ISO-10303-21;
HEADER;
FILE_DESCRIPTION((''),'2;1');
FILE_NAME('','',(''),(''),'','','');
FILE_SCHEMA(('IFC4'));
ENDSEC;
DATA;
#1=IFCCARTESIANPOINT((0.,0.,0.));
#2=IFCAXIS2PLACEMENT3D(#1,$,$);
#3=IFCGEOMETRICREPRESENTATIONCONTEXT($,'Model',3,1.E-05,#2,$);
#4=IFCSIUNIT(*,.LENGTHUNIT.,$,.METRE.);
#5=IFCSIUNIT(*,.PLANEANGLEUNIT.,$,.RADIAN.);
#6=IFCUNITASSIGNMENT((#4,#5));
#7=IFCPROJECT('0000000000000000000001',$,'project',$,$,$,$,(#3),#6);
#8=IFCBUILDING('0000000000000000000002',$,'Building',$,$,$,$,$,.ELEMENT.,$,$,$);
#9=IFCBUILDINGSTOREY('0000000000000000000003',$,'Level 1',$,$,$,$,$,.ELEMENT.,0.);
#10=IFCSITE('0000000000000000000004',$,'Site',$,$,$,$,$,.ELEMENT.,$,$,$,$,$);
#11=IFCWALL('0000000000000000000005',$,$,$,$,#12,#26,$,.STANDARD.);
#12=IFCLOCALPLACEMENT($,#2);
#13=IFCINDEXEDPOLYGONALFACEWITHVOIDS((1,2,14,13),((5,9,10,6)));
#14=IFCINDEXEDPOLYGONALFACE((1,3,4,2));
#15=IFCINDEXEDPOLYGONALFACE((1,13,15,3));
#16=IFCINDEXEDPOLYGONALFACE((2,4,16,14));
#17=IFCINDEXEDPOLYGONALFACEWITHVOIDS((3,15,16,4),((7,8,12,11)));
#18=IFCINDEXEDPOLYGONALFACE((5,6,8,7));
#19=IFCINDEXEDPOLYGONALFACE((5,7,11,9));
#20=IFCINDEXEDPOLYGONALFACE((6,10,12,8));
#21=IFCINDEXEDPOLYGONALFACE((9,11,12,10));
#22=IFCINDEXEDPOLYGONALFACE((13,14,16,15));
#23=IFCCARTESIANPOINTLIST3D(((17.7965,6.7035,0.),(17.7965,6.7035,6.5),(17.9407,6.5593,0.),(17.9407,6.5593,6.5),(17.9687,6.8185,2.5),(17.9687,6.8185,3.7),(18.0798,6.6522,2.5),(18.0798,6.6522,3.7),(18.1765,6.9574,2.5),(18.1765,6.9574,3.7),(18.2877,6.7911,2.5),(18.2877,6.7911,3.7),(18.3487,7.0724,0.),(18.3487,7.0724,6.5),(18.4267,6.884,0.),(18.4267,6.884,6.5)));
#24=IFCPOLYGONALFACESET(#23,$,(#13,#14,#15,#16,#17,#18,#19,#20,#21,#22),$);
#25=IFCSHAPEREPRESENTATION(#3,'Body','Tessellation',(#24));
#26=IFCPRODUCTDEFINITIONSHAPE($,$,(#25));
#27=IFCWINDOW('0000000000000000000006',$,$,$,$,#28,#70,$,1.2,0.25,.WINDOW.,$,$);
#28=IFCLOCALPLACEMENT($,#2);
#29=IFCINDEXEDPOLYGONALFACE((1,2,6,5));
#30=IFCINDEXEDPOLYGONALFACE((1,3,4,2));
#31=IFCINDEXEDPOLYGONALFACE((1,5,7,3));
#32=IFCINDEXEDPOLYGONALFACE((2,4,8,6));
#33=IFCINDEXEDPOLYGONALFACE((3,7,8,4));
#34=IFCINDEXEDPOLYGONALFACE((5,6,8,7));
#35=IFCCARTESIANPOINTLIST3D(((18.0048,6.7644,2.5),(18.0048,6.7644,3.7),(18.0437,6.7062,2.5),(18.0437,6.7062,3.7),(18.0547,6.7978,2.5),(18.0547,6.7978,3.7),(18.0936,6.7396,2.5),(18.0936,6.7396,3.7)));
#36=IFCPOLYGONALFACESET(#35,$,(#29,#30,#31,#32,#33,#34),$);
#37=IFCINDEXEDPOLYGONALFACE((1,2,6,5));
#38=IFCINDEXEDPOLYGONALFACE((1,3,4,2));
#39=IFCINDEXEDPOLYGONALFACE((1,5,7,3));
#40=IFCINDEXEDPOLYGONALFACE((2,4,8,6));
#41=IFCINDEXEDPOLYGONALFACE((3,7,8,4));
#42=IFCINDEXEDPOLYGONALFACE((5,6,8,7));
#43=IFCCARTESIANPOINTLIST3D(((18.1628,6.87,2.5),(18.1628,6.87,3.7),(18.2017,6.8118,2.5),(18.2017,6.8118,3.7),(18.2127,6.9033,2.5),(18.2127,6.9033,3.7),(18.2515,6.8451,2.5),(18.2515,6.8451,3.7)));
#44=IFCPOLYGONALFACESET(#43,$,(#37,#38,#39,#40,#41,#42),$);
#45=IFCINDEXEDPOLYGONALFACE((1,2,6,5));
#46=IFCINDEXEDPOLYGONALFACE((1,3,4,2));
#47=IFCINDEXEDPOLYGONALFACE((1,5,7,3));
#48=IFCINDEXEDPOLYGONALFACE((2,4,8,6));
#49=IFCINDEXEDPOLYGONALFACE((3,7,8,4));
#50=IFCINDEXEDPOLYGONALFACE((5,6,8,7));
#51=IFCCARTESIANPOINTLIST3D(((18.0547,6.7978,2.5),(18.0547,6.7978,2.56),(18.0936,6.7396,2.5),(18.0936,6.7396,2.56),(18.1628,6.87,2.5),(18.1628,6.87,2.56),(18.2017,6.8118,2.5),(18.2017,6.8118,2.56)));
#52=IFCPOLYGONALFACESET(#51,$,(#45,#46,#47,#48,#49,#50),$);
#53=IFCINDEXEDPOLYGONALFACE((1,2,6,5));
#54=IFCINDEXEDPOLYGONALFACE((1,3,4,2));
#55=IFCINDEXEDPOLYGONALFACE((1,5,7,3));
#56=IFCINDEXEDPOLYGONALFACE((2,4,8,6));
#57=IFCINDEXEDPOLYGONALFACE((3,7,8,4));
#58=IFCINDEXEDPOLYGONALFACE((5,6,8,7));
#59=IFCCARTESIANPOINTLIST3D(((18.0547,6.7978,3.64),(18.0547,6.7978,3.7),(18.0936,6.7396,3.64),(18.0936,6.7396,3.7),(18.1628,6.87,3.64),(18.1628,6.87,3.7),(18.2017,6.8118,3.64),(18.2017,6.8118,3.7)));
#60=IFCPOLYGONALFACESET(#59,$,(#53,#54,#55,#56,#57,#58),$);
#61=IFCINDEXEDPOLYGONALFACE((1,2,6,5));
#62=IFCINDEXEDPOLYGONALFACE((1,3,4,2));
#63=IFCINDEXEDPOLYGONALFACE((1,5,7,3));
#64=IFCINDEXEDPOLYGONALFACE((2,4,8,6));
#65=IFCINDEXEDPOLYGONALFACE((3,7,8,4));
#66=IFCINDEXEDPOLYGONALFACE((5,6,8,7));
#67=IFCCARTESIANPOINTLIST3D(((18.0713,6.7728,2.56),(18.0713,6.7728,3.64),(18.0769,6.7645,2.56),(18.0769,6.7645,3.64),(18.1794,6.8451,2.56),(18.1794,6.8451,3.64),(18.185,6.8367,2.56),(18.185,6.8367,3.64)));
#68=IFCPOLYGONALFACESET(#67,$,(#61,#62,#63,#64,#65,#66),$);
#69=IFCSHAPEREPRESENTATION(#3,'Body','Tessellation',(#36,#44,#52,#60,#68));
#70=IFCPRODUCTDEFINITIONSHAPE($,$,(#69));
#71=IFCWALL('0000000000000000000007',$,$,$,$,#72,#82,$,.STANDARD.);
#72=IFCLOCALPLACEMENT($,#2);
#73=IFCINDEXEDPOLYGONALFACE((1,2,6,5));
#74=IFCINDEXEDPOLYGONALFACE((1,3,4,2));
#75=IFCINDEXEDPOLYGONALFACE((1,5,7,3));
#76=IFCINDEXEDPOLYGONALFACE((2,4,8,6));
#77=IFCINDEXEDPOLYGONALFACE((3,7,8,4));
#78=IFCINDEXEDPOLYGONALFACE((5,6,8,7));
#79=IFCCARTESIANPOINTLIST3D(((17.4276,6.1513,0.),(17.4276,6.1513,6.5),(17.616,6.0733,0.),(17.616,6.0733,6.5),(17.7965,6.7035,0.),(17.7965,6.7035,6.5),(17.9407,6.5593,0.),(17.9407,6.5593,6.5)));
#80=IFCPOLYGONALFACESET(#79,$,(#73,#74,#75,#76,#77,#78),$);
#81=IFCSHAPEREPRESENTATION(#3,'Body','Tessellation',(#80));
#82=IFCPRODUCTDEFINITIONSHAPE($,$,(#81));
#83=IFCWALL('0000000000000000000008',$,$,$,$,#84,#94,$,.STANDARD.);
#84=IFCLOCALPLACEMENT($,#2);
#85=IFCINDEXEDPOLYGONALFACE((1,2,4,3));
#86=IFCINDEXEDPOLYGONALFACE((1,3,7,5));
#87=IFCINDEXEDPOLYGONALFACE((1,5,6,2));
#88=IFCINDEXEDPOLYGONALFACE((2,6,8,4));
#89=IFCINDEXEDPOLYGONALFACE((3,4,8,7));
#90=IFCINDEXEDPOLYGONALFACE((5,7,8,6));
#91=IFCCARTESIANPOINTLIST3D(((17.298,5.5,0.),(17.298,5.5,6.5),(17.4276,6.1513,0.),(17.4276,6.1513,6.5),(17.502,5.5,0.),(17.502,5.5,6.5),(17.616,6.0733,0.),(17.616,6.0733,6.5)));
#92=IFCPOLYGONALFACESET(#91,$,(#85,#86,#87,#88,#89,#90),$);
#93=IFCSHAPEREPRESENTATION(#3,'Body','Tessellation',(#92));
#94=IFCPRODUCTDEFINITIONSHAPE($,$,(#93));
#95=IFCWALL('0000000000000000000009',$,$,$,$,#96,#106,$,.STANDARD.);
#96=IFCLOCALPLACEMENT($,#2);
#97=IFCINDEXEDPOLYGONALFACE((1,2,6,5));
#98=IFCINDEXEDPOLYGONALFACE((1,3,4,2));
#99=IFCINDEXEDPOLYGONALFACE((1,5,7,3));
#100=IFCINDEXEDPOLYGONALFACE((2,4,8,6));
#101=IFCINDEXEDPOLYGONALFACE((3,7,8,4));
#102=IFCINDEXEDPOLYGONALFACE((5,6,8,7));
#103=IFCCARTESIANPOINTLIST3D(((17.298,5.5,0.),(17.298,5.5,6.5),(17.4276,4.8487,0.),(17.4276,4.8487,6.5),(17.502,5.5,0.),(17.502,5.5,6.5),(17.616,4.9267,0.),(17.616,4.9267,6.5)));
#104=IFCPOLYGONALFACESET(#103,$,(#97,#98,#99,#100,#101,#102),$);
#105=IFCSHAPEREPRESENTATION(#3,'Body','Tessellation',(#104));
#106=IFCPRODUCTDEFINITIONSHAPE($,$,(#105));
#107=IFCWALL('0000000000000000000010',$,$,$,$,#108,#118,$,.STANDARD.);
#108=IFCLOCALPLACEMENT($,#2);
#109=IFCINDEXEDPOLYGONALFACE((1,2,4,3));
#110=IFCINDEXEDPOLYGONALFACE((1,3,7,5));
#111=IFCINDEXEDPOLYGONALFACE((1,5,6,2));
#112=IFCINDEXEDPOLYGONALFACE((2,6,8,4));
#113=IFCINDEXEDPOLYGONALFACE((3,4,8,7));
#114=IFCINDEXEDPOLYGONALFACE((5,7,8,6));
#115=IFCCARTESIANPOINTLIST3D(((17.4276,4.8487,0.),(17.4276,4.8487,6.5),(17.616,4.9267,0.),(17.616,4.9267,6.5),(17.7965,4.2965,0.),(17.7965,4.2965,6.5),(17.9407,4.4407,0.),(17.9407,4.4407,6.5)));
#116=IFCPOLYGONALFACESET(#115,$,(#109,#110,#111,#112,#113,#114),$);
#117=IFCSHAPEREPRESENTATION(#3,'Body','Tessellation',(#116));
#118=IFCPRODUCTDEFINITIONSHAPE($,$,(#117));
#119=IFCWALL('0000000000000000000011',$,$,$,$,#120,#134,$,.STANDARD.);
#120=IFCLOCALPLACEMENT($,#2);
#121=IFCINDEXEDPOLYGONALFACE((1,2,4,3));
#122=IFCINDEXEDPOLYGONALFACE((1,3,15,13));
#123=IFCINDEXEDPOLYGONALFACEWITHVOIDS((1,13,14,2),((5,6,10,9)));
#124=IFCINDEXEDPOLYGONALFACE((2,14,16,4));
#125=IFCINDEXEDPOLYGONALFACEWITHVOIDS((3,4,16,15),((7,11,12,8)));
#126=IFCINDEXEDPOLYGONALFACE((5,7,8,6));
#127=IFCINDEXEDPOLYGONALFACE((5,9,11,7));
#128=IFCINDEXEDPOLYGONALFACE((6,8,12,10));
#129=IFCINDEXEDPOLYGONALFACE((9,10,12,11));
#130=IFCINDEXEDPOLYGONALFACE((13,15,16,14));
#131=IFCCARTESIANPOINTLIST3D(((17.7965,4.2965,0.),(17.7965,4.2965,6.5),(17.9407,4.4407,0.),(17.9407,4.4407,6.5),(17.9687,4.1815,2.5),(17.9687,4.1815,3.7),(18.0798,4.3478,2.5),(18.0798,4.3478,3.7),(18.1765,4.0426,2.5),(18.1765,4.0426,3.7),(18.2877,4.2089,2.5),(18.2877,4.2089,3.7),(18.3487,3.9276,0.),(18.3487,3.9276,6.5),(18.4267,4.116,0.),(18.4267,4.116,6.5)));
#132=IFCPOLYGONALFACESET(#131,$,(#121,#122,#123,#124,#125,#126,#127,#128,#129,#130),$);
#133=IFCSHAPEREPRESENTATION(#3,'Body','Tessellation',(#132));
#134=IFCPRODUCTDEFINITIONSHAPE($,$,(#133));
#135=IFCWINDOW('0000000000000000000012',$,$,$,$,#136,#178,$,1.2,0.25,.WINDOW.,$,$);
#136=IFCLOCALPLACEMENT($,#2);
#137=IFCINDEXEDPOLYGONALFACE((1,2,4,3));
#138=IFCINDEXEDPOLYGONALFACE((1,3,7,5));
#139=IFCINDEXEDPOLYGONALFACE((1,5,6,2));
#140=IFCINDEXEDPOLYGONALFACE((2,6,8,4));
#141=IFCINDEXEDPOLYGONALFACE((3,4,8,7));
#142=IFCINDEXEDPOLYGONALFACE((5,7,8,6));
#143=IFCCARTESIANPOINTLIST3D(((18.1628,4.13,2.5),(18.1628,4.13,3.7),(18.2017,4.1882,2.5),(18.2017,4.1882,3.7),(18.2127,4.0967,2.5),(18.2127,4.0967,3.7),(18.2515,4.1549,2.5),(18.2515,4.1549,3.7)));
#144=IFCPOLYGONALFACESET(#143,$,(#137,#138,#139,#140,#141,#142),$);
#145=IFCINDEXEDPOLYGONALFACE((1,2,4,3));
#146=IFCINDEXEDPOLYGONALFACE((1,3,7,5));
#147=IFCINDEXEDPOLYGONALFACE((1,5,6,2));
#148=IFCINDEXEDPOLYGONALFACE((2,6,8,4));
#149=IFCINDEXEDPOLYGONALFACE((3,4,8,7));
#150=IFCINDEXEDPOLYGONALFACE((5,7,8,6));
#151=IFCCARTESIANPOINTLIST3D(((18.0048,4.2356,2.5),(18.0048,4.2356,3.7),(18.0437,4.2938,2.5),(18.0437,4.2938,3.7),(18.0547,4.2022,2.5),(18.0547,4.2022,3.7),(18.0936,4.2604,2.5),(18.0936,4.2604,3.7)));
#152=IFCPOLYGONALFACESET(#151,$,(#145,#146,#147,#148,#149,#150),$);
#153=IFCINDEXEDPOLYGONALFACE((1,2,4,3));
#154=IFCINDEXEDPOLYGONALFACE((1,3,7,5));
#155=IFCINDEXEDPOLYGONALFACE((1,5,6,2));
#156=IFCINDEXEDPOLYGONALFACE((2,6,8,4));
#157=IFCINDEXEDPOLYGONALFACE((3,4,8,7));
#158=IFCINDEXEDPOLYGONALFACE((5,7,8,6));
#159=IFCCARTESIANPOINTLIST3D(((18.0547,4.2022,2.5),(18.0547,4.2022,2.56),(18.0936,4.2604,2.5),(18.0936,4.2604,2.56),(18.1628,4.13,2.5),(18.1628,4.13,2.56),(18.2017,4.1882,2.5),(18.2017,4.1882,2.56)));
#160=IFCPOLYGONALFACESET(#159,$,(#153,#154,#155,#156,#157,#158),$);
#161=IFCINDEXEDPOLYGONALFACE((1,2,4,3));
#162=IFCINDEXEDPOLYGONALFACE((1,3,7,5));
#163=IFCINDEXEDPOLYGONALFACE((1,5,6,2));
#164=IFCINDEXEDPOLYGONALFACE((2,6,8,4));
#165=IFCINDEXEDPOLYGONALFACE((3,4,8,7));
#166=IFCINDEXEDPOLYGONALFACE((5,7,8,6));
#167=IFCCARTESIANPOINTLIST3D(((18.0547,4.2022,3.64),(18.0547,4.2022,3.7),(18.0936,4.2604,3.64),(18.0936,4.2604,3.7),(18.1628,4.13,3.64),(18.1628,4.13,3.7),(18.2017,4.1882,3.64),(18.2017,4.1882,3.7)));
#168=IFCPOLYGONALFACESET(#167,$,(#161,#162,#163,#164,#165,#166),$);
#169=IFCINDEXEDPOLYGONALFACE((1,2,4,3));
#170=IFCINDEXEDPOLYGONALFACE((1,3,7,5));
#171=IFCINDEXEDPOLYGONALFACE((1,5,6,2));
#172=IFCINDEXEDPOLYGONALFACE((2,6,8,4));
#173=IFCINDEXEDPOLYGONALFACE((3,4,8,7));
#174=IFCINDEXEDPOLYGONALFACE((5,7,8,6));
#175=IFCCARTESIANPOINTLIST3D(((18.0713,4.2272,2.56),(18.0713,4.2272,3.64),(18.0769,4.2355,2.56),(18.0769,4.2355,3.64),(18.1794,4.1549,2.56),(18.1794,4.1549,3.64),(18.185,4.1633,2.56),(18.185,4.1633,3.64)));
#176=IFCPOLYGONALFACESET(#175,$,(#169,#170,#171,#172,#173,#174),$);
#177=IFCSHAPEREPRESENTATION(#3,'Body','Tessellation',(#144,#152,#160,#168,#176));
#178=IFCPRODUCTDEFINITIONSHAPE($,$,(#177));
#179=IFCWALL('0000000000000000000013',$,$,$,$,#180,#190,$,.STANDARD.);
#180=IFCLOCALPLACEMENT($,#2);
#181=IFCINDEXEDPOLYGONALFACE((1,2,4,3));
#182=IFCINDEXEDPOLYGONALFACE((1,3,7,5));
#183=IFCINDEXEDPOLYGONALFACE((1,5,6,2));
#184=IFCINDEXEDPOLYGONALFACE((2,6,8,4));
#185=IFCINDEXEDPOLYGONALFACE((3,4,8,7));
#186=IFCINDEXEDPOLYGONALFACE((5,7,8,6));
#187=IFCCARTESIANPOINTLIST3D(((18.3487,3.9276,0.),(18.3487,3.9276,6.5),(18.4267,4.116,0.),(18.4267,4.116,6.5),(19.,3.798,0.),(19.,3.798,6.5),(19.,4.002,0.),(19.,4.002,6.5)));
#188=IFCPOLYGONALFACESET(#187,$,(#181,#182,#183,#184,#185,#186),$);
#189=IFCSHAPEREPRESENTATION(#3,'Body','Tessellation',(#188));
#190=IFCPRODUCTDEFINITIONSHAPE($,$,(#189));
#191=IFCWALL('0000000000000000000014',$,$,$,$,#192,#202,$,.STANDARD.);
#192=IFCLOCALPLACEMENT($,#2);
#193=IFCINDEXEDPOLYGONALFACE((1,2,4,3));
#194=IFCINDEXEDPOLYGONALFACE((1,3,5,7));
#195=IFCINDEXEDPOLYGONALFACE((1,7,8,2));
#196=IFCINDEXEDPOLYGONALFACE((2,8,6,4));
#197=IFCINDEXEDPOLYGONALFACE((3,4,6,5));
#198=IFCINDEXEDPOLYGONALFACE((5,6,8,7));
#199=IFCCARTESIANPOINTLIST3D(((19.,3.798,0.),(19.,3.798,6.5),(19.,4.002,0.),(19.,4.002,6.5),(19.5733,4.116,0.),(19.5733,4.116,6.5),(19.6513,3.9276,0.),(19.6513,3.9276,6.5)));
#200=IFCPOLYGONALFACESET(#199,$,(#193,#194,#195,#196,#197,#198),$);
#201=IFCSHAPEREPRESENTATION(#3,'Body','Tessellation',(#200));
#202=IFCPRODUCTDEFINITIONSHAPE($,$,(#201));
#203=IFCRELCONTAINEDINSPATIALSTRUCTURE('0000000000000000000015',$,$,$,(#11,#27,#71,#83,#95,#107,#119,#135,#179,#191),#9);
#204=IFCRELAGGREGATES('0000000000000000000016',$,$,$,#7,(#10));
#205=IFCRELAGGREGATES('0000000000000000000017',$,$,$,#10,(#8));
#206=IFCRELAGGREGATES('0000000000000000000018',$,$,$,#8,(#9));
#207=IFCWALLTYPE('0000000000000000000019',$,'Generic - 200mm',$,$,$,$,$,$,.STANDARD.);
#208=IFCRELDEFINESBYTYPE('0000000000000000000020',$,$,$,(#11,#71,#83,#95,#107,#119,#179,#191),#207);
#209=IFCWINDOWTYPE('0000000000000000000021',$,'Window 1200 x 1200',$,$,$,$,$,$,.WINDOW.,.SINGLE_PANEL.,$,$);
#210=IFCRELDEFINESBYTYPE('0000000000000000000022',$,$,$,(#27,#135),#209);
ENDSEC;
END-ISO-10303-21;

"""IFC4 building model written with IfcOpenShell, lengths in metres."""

from ifc_helpers import new_model, si_unit, frame, frame_2d, origin, origin_with_axes, origin_2d, place, context, project, spatial, polyline, rectangle, outline, extrude, type_object, element, fill, save


model = new_model("IFC4")

# Units and contexts
model_context = context("Model", 3, precision=1e-05, world=origin())
ifc_project = project(units=[si_unit("LENGTHUNIT", "METRE"), si_unit("PLANEANGLEUNIT", "RADIAN")], contexts=[model_context])

# Site, building, storey
site = spatial("IfcSite", under=ifc_project, Name="Site", CompositionType="ELEMENT")
building = spatial("IfcBuilding", under=site, Name="Building", CompositionType="ELEMENT")
storey = spatial("IfcBuildingStorey", under=building, Name="Level 1", CompositionType="ELEMENT", Elevation=0.0)

# Shared definitions
wall_type_1 = type_object("IfcWallType", Name="Generic - 200mm", PredefinedType="STANDARD")

# Shared definitions
window_type = type_object("IfcWindowType", Name="Window 1200 x 1200", PartitioningType="SINGLE_PANEL", PredefinedType="WINDOW")

# Wall, opening, window
wall_1_placement = place(None, frame((17.8686, 6.6314, 0.0), z_axis=(0.0, 0.0, 1.0), x_axis=(0.83147, 0.55557, 0.0)))
wall_1 = element("IfcWall", 1, at=wall_1_placement, inside=storey, type_object=wall_type_1, PredefinedType="STANDARD", context=model_context, shape_type="SweptSolid", body=[
    extrude(outline(polyline([(0.0199, -0.1), (0.6044, -0.1), (0.6442, 0.1), (-0.0199, 0.1), (0.0199, -0.1)])), origin(), (0.0, 0.0, 1.0), 6.5),
])
opening_1_placement = place(wall_1_placement, frame((0.3121, 0.0, 2.5), z_axis=(0.0, 0.0, 1.0), x_axis=(1.0, 0.0, 0.0)))
opening_1 = element("IfcOpeningElement", 2, at=opening_1_placement, cuts=wall_1, PredefinedType="OPENING", context=model_context, shape_type="SweptSolid", body=[
    extrude(rectangle(XDim=0.25, YDim=0.202, at=origin_2d()), origin(), (0.0, 0.0, 1.0), 1.2),
])
window_1_placement = place(opening_1_placement, origin_with_axes())
window_1 = element("IfcWindow", 3, at=window_1_placement, inside=storey, type_object=window_type, OverallHeight=1.2, OverallWidth=0.25, PredefinedType="WINDOW", context=model_context, shape_type="SweptSolid", body=[
    extrude(rectangle(XDim=0.06, YDim=0.07, at=frame_2d((-0.095, 0.0))), origin(), (0.0, 0.0, 1.0), 1.2),
    extrude(rectangle(XDim=0.06, YDim=0.07, at=frame_2d((0.095, 0.0))), origin(), (0.0, 0.0, 1.0), 1.2),
    extrude(rectangle(XDim=0.13, YDim=0.07, at=origin_2d()), origin(), (0.0, 0.0, 1.0), 0.06),
    extrude(rectangle(XDim=0.13, YDim=0.07, at=origin_2d()), frame((0.0, 0.0, 1.14)), (0.0, 0.0, 1.0), 0.06),
    extrude(rectangle(XDim=0.13, YDim=0.01, at=origin_2d()), frame((0.0, 0.0, 0.06)), (0.0, 0.0, 1.0), 1.08),
])
fill(opening_1, window_1)

# Walls
wall_2_placement = place(None, frame((17.5218, 6.1123, 0.0), z_axis=(0.0, 0.0, 1.0), x_axis=(0.55557, 0.83147, 0.0)))
element("IfcWall", 4, at=wall_2_placement, inside=storey, type_object=wall_type_1, PredefinedType="STANDARD", context=model_context, shape_type="SweptSolid", body=[
    extrude(outline(polyline([(0.0199, -0.1), (0.6044, -0.1), (0.6442, 0.1), (-0.0199, 0.1), (0.0199, -0.1)])), origin(), (0.0, 0.0, 1.0), 6.5),
])
wall_3_placement = place(None, frame((17.4, 5.5, 0.0), z_axis=(0.0, 0.0, 1.0), x_axis=(0.19509, 0.980785, 0.0)))
element("IfcWall", 5, at=wall_3_placement, inside=storey, type_object=wall_type_1, PredefinedType="STANDARD", context=model_context, shape_type="SweptSolid", body=[
    extrude(outline(polyline([(0.0199, -0.1), (0.6044, -0.1), (0.6442, 0.1), (-0.0199, 0.1), (0.0199, -0.1)])), origin(), (0.0, 0.0, 1.0), 6.5),
])
wall_4_placement = place(None, frame((17.5218, 4.8877, 0.0), z_axis=(0.0, 0.0, 1.0), x_axis=(-0.19509, 0.980785, 0.0)))
element("IfcWall", 6, at=wall_4_placement, inside=storey, type_object=wall_type_1, PredefinedType="STANDARD", context=model_context, shape_type="SweptSolid", body=[
    extrude(outline(polyline([(0.0199, -0.1), (0.6044, -0.1), (0.6442, 0.1), (-0.0199, 0.1), (0.0199, -0.1)])), origin(), (0.0, 0.0, 1.0), 6.5),
])
wall_5_placement = place(None, frame((17.8686, 4.3686, 0.0), z_axis=(0.0, 0.0, 1.0), x_axis=(-0.55557, 0.83147, 0.0)))
element("IfcWall", 7, at=wall_5_placement, inside=storey, type_object=wall_type_1, PredefinedType="STANDARD", context=model_context, shape_type="SweptSolid", body=[
    extrude(outline(polyline([(0.0199, -0.1), (0.6044, -0.1), (0.6442, 0.1), (-0.0199, 0.1), (0.0199, -0.1)])), origin(), (0.0, 0.0, 1.0), 6.5),
])

# Wall, opening, window
wall_6_placement = place(None, frame((18.3877, 4.0218, 0.0), z_axis=(0.0, 0.0, 1.0), x_axis=(-0.83147, 0.55557, 0.0)))
wall_6 = element("IfcWall", 8, at=wall_6_placement, inside=storey, type_object=wall_type_1, PredefinedType="STANDARD", context=model_context, shape_type="SweptSolid", body=[
    extrude(outline(polyline([(0.0199, -0.1), (0.6044, -0.1), (0.6442, 0.1), (-0.0199, 0.1), (0.0199, -0.1)])), origin(), (0.0, 0.0, 1.0), 6.5),
])
opening_2_placement = place(wall_6_placement, frame((0.3121, 0.0, 2.5), z_axis=(0.0, 0.0, 1.0), x_axis=(1.0, 0.0, 0.0)))
opening_2 = element("IfcOpeningElement", 9, at=opening_2_placement, cuts=wall_6, PredefinedType="OPENING", context=model_context, shape_type="SweptSolid", body=[
    extrude(rectangle(XDim=0.25, YDim=0.202, at=origin_2d()), origin(), (0.0, 0.0, 1.0), 1.2),
])
window_2_placement = place(opening_2_placement, origin_with_axes())
window_2 = element("IfcWindow", 10, at=window_2_placement, inside=storey, type_object=window_type, OverallHeight=1.2, OverallWidth=0.25, PredefinedType="WINDOW", context=model_context, shape_type="SweptSolid", body=[
    extrude(rectangle(XDim=0.06, YDim=0.07, at=frame_2d((-0.095, 0.0))), origin(), (0.0, 0.0, 1.0), 1.2),
    extrude(rectangle(XDim=0.06, YDim=0.07, at=frame_2d((0.095, 0.0))), origin(), (0.0, 0.0, 1.0), 1.2),
    extrude(rectangle(XDim=0.13, YDim=0.07, at=origin_2d()), origin(), (0.0, 0.0, 1.0), 0.06),
    extrude(rectangle(XDim=0.13, YDim=0.07, at=origin_2d()), frame((0.0, 0.0, 1.14)), (0.0, 0.0, 1.0), 0.06),
    extrude(rectangle(XDim=0.13, YDim=0.01, at=origin_2d()), frame((0.0, 0.0, 0.06)), (0.0, 0.0, 1.0), 1.08),
])
fill(opening_2, window_2)

# Walls
wall_7_placement = place(None, frame((19.0, 3.9, 0.0), z_axis=(0.0, 0.0, 1.0), x_axis=(-0.980785, 0.19509, 0.0)))
element("IfcWall", 11, at=wall_7_placement, inside=storey, type_object=wall_type_1, PredefinedType="STANDARD", context=model_context, shape_type="SweptSolid", body=[
    extrude(outline(polyline([(0.0199, -0.1), (0.6044, -0.1), (0.6442, 0.1), (-0.0199, 0.1), (0.0199, -0.1)])), origin(), (0.0, 0.0, 1.0), 6.5),
])
wall_8_placement = place(None, frame((19.6123, 4.0218, 0.0), z_axis=(0.0, 0.0, 1.0), x_axis=(-0.980785, -0.19509, 0.0)))
element("IfcWall", 12, at=wall_8_placement, inside=storey, type_object=wall_type_1, PredefinedType="STANDARD", context=model_context, shape_type="SweptSolid", body=[
    extrude(outline(polyline([(0.0199, -0.1), (0.6044, -0.1), (0.6442, 0.1), (-0.0199, 0.1), (0.0199, -0.1)])), origin(), (0.0, 0.0, 1.0), 6.5),
])

save(model, "model.ifc")
